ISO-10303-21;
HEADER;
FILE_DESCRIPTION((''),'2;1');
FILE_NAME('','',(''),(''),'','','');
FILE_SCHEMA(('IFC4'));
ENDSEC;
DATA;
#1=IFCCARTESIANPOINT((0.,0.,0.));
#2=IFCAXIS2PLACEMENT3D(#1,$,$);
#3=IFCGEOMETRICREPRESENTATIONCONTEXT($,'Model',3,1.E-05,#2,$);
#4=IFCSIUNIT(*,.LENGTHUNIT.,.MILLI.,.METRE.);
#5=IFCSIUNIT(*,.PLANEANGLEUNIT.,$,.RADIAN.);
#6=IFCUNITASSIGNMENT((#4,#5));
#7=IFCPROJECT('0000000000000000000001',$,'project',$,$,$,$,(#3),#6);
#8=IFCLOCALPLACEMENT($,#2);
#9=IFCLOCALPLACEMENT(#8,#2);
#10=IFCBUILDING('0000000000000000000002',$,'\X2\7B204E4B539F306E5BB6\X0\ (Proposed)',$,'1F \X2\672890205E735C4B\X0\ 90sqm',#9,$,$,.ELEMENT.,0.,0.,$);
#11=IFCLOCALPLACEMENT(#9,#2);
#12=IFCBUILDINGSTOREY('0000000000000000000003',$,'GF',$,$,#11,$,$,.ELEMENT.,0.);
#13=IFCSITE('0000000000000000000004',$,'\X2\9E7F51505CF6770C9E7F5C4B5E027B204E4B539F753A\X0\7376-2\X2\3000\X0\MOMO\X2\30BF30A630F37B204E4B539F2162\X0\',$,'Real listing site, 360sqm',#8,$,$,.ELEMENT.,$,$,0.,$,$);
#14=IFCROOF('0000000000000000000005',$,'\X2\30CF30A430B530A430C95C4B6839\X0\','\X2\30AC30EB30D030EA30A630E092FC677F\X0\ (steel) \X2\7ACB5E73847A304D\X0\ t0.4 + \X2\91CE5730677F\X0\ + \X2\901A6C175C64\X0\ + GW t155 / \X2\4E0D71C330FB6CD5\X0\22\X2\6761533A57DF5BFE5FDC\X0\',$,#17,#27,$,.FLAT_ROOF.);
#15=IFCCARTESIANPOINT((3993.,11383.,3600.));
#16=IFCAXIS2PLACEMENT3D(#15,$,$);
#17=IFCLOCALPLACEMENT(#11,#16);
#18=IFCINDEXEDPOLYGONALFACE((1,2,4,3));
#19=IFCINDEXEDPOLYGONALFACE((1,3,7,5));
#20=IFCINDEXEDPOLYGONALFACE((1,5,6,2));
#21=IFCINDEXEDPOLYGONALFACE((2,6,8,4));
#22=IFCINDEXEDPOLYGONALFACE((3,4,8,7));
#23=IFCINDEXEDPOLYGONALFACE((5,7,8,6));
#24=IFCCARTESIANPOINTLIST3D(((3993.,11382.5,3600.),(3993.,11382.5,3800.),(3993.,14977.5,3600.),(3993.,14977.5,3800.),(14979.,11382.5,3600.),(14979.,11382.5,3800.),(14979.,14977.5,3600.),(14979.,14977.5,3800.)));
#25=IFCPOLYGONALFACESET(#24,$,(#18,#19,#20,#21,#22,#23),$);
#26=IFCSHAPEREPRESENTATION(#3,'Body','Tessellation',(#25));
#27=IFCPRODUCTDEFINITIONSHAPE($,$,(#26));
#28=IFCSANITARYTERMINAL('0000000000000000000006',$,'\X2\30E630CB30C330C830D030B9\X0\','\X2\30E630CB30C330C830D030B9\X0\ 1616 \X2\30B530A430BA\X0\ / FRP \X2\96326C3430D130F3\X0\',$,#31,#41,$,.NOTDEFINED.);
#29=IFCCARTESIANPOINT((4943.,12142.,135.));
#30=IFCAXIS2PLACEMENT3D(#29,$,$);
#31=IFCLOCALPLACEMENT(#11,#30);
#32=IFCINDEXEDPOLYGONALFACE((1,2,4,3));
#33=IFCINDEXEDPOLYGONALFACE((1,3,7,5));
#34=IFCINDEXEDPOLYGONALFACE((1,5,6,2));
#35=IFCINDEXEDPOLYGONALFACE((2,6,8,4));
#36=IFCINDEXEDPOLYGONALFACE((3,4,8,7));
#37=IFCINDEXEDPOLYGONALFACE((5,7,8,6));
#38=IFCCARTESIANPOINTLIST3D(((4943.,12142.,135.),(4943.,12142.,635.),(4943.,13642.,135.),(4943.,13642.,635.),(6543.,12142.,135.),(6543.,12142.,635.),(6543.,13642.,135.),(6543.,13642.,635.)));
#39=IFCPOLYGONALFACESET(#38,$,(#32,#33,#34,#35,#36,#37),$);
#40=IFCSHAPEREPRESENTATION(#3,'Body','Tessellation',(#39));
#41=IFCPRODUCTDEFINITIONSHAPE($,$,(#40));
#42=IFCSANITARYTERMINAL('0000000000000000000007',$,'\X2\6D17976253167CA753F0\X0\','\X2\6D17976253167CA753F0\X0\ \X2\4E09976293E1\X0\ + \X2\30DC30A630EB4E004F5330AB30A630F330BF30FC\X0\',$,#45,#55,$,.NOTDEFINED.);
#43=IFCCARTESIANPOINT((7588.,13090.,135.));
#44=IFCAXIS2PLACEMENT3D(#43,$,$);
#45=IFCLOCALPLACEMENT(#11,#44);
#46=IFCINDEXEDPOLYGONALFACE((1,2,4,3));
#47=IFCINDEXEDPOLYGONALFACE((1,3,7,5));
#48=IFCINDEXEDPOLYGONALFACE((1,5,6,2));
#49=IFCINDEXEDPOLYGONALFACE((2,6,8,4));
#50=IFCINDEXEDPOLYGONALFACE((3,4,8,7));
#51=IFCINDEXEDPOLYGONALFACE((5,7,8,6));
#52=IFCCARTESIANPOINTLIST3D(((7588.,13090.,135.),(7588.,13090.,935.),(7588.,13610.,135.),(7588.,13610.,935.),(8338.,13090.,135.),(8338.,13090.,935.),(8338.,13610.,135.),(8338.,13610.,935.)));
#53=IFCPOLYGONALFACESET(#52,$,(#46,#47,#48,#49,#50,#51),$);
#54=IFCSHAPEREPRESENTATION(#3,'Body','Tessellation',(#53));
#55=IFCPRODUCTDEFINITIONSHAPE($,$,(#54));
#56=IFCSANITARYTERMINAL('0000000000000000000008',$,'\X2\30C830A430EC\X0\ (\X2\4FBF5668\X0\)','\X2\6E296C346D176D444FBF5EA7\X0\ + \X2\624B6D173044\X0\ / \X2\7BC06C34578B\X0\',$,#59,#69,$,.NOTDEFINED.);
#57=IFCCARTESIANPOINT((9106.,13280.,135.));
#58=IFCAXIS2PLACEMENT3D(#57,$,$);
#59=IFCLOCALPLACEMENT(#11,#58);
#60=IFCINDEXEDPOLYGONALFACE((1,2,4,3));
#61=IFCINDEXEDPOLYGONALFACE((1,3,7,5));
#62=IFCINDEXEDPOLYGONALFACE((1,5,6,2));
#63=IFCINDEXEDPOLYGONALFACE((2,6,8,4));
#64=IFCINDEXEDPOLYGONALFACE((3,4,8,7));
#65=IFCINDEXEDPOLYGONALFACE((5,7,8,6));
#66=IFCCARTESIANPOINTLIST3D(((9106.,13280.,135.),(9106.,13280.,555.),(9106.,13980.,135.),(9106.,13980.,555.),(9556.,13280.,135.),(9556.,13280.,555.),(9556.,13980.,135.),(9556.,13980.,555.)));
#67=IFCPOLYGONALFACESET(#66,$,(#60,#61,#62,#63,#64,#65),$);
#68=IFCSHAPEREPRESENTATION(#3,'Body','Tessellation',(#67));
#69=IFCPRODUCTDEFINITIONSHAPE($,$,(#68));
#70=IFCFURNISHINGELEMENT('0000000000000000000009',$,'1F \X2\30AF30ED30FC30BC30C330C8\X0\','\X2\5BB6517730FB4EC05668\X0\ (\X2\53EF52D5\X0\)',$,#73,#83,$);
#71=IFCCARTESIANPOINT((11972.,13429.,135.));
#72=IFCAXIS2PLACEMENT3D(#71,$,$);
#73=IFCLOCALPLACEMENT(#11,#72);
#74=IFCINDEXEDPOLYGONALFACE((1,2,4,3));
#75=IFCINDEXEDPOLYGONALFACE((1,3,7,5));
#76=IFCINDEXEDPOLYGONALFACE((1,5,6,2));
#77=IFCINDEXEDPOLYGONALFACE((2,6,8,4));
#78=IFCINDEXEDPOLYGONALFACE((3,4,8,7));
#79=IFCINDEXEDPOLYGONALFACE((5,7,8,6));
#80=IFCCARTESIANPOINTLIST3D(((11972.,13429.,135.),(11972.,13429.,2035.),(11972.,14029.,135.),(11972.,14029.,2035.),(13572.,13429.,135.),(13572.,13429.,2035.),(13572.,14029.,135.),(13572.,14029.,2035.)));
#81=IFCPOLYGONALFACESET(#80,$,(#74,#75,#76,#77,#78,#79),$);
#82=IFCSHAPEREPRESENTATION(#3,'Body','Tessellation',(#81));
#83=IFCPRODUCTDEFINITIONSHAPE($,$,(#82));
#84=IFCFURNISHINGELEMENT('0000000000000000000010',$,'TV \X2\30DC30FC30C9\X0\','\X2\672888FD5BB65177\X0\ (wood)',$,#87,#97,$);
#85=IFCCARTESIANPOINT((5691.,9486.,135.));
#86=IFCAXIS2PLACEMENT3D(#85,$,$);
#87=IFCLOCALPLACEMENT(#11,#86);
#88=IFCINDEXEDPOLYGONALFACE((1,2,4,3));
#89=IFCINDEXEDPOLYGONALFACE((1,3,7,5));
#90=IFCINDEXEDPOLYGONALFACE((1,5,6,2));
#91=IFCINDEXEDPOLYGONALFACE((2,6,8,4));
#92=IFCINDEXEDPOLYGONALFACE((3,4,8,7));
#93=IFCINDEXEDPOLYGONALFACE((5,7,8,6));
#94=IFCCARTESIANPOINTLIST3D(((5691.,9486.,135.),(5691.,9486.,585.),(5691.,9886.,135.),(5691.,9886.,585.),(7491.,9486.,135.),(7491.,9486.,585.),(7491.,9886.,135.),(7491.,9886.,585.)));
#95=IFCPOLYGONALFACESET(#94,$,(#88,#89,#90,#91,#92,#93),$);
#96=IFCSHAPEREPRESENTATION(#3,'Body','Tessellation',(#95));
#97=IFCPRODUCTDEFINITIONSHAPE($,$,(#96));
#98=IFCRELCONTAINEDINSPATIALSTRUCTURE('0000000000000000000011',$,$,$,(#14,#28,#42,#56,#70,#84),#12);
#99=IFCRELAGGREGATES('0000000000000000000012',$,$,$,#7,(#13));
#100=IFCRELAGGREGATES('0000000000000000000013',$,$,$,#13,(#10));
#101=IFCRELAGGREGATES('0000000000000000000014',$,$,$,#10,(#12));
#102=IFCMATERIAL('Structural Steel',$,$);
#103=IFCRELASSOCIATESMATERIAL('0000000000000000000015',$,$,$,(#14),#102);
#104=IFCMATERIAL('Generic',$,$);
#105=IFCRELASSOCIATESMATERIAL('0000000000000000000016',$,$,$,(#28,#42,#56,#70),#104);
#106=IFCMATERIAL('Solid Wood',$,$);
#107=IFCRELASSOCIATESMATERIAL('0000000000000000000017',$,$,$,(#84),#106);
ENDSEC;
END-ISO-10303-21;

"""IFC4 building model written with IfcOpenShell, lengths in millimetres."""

from ifc_helpers import new_model, si_unit, frame, frame_2d, origin, place, context, project, spatial, rectangle, extrude, material, element, save


model = new_model("IFC4")

# Units and contexts
model_context = context("Model", 3, precision=1e-05, world=origin())
ifc_project = project(units=[si_unit("LENGTHUNIT", "METRE", prefix="MILLI"), si_unit("PLANEANGLEUNIT", "RADIAN")], contexts=[model_context])

# Site, building, storey
site_placement = place(None, origin())
site = spatial("IfcSite", under=ifc_project, at=site_placement, Name="鹿児島県鹿屋市笠之原町7376-2　MOMOタウン笠之原Ⅲ", ObjectType="Real listing site, 360sqm", CompositionType="ELEMENT", RefElevation=0.0)
building_placement = place(site_placement, origin())
building = spatial("IfcBuilding", under=site, at=building_placement, Name="笠之原の家 (Proposed)", ObjectType="1F 木造平屋 90sqm", CompositionType="ELEMENT", ElevationOfRefHeight=0.0, ElevationOfTerrain=0.0)
storey_placement = place(building_placement, origin())
storey = spatial("IfcBuildingStorey", under=building, at=storey_placement, Name="GF", CompositionType="ELEMENT", Elevation=0.0)

# Shared definitions
ifc_material_1 = material(Name="Solid Wood")

# Roof
ifc_material_2 = material(Name="Structural Steel")
roof_placement = place(storey_placement, frame((3993.0, 11383.0, 3600.0)))
element("IfcRoof", 1, at=roof_placement, inside=storey, material=ifc_material_2, Name="ハイサイド屋根", Description="ガルバリウム鋼板 (steel) 立平葺き t0.4 + 野地板 + 通気層 + GW t155 / 不燃・法22条区域対応", PredefinedType="FLAT_ROOF", context=model_context, shape_type="SweptSolid", body=[
    extrude(rectangle(XDim=10986.0, YDim=3595.0, at=frame_2d((5493.0, 1797.0))), frame((3993.0, 11383.0, 3600.0)), (0.0, 0.0, 1.0), 200.0),
])

# Sanitary terminals
ifc_material_3 = material(Name="Generic")
sanitary_terminal_1_placement = place(storey_placement, frame((4943.0, 12142.0, 135.0)))
element("IfcSanitaryTerminal", 2, at=sanitary_terminal_1_placement, inside=storey, material=ifc_material_3, Name="ユニットバス", Description="ユニットバス 1616 サイズ / FRP 防水パン", PredefinedType="NOTDEFINED", context=model_context, shape_type="SweptSolid", body=[
    extrude(rectangle(XDim=1600.0, YDim=1500.0, at=frame_2d((800.0, 750.0))), frame((4943.0, 12142.0, 135.0)), (0.0, 0.0, 1.0), 500.0),
])
sanitary_terminal_2_placement = place(storey_placement, frame((7588.0, 13090.0, 135.0)))
element("IfcSanitaryTerminal", 3, at=sanitary_terminal_2_placement, inside=storey, material=ifc_material_3, Name="洗面化粧台", Description="洗面化粧台 三面鏡 + ボウル一体カウンター", PredefinedType="NOTDEFINED", context=model_context, shape_type="SweptSolid", body=[
    extrude(rectangle(XDim=750.0, YDim=520.0, at=frame_2d((375.0, 260.0))), frame((7588.0, 13090.0, 135.0)), (0.0, 0.0, 1.0), 800.0),
])
sanitary_terminal_3_placement = place(storey_placement, frame((9106.0, 13280.0, 135.0)))
element("IfcSanitaryTerminal", 4, at=sanitary_terminal_3_placement, inside=storey, material=ifc_material_3, Name="トイレ (便器)", Description="温水洗浄便座 + 手洗い / 節水型", PredefinedType="NOTDEFINED", context=model_context, shape_type="SweptSolid", body=[
    extrude(rectangle(XDim=450.0, YDim=700.0, at=frame_2d((225.0, 350.0))), frame((9106.0, 13280.0, 135.0)), (0.0, 0.0, 1.0), 420.0),
])

# Furnishing elements
furnishing_1_placement = place(storey_placement, frame((11972.0, 13429.0, 135.0)))
element("IfcFurnishingElement", 5, at=furnishing_1_placement, inside=storey, material=ifc_material_3, Name="1F クローゼット", Description="家具・什器 (可動)", context=model_context, shape_type="SweptSolid", body=[
    extrude(rectangle(XDim=1600.0, YDim=600.0, at=frame_2d((800.0, 300.0))), frame((11972.0, 13429.0, 135.0)), (0.0, 0.0, 1.0), 1900.0),
])
furnishing_2_placement = place(storey_placement, frame((5691.0, 9486.0, 135.0)))
element("IfcFurnishingElement", 6, at=furnishing_2_placement, inside=storey, material=ifc_material_1, Name="TV ボード", Description="木製家具 (wood)", context=model_context, shape_type="SweptSolid", body=[
    extrude(rectangle(XDim=1800.0, YDim=400.0, at=frame_2d((900.0, 200.0))), frame((5691.0, 9486.0, 135.0)), (0.0, 0.0, 1.0), 450.0),
])

save(model, "model.ifc")
